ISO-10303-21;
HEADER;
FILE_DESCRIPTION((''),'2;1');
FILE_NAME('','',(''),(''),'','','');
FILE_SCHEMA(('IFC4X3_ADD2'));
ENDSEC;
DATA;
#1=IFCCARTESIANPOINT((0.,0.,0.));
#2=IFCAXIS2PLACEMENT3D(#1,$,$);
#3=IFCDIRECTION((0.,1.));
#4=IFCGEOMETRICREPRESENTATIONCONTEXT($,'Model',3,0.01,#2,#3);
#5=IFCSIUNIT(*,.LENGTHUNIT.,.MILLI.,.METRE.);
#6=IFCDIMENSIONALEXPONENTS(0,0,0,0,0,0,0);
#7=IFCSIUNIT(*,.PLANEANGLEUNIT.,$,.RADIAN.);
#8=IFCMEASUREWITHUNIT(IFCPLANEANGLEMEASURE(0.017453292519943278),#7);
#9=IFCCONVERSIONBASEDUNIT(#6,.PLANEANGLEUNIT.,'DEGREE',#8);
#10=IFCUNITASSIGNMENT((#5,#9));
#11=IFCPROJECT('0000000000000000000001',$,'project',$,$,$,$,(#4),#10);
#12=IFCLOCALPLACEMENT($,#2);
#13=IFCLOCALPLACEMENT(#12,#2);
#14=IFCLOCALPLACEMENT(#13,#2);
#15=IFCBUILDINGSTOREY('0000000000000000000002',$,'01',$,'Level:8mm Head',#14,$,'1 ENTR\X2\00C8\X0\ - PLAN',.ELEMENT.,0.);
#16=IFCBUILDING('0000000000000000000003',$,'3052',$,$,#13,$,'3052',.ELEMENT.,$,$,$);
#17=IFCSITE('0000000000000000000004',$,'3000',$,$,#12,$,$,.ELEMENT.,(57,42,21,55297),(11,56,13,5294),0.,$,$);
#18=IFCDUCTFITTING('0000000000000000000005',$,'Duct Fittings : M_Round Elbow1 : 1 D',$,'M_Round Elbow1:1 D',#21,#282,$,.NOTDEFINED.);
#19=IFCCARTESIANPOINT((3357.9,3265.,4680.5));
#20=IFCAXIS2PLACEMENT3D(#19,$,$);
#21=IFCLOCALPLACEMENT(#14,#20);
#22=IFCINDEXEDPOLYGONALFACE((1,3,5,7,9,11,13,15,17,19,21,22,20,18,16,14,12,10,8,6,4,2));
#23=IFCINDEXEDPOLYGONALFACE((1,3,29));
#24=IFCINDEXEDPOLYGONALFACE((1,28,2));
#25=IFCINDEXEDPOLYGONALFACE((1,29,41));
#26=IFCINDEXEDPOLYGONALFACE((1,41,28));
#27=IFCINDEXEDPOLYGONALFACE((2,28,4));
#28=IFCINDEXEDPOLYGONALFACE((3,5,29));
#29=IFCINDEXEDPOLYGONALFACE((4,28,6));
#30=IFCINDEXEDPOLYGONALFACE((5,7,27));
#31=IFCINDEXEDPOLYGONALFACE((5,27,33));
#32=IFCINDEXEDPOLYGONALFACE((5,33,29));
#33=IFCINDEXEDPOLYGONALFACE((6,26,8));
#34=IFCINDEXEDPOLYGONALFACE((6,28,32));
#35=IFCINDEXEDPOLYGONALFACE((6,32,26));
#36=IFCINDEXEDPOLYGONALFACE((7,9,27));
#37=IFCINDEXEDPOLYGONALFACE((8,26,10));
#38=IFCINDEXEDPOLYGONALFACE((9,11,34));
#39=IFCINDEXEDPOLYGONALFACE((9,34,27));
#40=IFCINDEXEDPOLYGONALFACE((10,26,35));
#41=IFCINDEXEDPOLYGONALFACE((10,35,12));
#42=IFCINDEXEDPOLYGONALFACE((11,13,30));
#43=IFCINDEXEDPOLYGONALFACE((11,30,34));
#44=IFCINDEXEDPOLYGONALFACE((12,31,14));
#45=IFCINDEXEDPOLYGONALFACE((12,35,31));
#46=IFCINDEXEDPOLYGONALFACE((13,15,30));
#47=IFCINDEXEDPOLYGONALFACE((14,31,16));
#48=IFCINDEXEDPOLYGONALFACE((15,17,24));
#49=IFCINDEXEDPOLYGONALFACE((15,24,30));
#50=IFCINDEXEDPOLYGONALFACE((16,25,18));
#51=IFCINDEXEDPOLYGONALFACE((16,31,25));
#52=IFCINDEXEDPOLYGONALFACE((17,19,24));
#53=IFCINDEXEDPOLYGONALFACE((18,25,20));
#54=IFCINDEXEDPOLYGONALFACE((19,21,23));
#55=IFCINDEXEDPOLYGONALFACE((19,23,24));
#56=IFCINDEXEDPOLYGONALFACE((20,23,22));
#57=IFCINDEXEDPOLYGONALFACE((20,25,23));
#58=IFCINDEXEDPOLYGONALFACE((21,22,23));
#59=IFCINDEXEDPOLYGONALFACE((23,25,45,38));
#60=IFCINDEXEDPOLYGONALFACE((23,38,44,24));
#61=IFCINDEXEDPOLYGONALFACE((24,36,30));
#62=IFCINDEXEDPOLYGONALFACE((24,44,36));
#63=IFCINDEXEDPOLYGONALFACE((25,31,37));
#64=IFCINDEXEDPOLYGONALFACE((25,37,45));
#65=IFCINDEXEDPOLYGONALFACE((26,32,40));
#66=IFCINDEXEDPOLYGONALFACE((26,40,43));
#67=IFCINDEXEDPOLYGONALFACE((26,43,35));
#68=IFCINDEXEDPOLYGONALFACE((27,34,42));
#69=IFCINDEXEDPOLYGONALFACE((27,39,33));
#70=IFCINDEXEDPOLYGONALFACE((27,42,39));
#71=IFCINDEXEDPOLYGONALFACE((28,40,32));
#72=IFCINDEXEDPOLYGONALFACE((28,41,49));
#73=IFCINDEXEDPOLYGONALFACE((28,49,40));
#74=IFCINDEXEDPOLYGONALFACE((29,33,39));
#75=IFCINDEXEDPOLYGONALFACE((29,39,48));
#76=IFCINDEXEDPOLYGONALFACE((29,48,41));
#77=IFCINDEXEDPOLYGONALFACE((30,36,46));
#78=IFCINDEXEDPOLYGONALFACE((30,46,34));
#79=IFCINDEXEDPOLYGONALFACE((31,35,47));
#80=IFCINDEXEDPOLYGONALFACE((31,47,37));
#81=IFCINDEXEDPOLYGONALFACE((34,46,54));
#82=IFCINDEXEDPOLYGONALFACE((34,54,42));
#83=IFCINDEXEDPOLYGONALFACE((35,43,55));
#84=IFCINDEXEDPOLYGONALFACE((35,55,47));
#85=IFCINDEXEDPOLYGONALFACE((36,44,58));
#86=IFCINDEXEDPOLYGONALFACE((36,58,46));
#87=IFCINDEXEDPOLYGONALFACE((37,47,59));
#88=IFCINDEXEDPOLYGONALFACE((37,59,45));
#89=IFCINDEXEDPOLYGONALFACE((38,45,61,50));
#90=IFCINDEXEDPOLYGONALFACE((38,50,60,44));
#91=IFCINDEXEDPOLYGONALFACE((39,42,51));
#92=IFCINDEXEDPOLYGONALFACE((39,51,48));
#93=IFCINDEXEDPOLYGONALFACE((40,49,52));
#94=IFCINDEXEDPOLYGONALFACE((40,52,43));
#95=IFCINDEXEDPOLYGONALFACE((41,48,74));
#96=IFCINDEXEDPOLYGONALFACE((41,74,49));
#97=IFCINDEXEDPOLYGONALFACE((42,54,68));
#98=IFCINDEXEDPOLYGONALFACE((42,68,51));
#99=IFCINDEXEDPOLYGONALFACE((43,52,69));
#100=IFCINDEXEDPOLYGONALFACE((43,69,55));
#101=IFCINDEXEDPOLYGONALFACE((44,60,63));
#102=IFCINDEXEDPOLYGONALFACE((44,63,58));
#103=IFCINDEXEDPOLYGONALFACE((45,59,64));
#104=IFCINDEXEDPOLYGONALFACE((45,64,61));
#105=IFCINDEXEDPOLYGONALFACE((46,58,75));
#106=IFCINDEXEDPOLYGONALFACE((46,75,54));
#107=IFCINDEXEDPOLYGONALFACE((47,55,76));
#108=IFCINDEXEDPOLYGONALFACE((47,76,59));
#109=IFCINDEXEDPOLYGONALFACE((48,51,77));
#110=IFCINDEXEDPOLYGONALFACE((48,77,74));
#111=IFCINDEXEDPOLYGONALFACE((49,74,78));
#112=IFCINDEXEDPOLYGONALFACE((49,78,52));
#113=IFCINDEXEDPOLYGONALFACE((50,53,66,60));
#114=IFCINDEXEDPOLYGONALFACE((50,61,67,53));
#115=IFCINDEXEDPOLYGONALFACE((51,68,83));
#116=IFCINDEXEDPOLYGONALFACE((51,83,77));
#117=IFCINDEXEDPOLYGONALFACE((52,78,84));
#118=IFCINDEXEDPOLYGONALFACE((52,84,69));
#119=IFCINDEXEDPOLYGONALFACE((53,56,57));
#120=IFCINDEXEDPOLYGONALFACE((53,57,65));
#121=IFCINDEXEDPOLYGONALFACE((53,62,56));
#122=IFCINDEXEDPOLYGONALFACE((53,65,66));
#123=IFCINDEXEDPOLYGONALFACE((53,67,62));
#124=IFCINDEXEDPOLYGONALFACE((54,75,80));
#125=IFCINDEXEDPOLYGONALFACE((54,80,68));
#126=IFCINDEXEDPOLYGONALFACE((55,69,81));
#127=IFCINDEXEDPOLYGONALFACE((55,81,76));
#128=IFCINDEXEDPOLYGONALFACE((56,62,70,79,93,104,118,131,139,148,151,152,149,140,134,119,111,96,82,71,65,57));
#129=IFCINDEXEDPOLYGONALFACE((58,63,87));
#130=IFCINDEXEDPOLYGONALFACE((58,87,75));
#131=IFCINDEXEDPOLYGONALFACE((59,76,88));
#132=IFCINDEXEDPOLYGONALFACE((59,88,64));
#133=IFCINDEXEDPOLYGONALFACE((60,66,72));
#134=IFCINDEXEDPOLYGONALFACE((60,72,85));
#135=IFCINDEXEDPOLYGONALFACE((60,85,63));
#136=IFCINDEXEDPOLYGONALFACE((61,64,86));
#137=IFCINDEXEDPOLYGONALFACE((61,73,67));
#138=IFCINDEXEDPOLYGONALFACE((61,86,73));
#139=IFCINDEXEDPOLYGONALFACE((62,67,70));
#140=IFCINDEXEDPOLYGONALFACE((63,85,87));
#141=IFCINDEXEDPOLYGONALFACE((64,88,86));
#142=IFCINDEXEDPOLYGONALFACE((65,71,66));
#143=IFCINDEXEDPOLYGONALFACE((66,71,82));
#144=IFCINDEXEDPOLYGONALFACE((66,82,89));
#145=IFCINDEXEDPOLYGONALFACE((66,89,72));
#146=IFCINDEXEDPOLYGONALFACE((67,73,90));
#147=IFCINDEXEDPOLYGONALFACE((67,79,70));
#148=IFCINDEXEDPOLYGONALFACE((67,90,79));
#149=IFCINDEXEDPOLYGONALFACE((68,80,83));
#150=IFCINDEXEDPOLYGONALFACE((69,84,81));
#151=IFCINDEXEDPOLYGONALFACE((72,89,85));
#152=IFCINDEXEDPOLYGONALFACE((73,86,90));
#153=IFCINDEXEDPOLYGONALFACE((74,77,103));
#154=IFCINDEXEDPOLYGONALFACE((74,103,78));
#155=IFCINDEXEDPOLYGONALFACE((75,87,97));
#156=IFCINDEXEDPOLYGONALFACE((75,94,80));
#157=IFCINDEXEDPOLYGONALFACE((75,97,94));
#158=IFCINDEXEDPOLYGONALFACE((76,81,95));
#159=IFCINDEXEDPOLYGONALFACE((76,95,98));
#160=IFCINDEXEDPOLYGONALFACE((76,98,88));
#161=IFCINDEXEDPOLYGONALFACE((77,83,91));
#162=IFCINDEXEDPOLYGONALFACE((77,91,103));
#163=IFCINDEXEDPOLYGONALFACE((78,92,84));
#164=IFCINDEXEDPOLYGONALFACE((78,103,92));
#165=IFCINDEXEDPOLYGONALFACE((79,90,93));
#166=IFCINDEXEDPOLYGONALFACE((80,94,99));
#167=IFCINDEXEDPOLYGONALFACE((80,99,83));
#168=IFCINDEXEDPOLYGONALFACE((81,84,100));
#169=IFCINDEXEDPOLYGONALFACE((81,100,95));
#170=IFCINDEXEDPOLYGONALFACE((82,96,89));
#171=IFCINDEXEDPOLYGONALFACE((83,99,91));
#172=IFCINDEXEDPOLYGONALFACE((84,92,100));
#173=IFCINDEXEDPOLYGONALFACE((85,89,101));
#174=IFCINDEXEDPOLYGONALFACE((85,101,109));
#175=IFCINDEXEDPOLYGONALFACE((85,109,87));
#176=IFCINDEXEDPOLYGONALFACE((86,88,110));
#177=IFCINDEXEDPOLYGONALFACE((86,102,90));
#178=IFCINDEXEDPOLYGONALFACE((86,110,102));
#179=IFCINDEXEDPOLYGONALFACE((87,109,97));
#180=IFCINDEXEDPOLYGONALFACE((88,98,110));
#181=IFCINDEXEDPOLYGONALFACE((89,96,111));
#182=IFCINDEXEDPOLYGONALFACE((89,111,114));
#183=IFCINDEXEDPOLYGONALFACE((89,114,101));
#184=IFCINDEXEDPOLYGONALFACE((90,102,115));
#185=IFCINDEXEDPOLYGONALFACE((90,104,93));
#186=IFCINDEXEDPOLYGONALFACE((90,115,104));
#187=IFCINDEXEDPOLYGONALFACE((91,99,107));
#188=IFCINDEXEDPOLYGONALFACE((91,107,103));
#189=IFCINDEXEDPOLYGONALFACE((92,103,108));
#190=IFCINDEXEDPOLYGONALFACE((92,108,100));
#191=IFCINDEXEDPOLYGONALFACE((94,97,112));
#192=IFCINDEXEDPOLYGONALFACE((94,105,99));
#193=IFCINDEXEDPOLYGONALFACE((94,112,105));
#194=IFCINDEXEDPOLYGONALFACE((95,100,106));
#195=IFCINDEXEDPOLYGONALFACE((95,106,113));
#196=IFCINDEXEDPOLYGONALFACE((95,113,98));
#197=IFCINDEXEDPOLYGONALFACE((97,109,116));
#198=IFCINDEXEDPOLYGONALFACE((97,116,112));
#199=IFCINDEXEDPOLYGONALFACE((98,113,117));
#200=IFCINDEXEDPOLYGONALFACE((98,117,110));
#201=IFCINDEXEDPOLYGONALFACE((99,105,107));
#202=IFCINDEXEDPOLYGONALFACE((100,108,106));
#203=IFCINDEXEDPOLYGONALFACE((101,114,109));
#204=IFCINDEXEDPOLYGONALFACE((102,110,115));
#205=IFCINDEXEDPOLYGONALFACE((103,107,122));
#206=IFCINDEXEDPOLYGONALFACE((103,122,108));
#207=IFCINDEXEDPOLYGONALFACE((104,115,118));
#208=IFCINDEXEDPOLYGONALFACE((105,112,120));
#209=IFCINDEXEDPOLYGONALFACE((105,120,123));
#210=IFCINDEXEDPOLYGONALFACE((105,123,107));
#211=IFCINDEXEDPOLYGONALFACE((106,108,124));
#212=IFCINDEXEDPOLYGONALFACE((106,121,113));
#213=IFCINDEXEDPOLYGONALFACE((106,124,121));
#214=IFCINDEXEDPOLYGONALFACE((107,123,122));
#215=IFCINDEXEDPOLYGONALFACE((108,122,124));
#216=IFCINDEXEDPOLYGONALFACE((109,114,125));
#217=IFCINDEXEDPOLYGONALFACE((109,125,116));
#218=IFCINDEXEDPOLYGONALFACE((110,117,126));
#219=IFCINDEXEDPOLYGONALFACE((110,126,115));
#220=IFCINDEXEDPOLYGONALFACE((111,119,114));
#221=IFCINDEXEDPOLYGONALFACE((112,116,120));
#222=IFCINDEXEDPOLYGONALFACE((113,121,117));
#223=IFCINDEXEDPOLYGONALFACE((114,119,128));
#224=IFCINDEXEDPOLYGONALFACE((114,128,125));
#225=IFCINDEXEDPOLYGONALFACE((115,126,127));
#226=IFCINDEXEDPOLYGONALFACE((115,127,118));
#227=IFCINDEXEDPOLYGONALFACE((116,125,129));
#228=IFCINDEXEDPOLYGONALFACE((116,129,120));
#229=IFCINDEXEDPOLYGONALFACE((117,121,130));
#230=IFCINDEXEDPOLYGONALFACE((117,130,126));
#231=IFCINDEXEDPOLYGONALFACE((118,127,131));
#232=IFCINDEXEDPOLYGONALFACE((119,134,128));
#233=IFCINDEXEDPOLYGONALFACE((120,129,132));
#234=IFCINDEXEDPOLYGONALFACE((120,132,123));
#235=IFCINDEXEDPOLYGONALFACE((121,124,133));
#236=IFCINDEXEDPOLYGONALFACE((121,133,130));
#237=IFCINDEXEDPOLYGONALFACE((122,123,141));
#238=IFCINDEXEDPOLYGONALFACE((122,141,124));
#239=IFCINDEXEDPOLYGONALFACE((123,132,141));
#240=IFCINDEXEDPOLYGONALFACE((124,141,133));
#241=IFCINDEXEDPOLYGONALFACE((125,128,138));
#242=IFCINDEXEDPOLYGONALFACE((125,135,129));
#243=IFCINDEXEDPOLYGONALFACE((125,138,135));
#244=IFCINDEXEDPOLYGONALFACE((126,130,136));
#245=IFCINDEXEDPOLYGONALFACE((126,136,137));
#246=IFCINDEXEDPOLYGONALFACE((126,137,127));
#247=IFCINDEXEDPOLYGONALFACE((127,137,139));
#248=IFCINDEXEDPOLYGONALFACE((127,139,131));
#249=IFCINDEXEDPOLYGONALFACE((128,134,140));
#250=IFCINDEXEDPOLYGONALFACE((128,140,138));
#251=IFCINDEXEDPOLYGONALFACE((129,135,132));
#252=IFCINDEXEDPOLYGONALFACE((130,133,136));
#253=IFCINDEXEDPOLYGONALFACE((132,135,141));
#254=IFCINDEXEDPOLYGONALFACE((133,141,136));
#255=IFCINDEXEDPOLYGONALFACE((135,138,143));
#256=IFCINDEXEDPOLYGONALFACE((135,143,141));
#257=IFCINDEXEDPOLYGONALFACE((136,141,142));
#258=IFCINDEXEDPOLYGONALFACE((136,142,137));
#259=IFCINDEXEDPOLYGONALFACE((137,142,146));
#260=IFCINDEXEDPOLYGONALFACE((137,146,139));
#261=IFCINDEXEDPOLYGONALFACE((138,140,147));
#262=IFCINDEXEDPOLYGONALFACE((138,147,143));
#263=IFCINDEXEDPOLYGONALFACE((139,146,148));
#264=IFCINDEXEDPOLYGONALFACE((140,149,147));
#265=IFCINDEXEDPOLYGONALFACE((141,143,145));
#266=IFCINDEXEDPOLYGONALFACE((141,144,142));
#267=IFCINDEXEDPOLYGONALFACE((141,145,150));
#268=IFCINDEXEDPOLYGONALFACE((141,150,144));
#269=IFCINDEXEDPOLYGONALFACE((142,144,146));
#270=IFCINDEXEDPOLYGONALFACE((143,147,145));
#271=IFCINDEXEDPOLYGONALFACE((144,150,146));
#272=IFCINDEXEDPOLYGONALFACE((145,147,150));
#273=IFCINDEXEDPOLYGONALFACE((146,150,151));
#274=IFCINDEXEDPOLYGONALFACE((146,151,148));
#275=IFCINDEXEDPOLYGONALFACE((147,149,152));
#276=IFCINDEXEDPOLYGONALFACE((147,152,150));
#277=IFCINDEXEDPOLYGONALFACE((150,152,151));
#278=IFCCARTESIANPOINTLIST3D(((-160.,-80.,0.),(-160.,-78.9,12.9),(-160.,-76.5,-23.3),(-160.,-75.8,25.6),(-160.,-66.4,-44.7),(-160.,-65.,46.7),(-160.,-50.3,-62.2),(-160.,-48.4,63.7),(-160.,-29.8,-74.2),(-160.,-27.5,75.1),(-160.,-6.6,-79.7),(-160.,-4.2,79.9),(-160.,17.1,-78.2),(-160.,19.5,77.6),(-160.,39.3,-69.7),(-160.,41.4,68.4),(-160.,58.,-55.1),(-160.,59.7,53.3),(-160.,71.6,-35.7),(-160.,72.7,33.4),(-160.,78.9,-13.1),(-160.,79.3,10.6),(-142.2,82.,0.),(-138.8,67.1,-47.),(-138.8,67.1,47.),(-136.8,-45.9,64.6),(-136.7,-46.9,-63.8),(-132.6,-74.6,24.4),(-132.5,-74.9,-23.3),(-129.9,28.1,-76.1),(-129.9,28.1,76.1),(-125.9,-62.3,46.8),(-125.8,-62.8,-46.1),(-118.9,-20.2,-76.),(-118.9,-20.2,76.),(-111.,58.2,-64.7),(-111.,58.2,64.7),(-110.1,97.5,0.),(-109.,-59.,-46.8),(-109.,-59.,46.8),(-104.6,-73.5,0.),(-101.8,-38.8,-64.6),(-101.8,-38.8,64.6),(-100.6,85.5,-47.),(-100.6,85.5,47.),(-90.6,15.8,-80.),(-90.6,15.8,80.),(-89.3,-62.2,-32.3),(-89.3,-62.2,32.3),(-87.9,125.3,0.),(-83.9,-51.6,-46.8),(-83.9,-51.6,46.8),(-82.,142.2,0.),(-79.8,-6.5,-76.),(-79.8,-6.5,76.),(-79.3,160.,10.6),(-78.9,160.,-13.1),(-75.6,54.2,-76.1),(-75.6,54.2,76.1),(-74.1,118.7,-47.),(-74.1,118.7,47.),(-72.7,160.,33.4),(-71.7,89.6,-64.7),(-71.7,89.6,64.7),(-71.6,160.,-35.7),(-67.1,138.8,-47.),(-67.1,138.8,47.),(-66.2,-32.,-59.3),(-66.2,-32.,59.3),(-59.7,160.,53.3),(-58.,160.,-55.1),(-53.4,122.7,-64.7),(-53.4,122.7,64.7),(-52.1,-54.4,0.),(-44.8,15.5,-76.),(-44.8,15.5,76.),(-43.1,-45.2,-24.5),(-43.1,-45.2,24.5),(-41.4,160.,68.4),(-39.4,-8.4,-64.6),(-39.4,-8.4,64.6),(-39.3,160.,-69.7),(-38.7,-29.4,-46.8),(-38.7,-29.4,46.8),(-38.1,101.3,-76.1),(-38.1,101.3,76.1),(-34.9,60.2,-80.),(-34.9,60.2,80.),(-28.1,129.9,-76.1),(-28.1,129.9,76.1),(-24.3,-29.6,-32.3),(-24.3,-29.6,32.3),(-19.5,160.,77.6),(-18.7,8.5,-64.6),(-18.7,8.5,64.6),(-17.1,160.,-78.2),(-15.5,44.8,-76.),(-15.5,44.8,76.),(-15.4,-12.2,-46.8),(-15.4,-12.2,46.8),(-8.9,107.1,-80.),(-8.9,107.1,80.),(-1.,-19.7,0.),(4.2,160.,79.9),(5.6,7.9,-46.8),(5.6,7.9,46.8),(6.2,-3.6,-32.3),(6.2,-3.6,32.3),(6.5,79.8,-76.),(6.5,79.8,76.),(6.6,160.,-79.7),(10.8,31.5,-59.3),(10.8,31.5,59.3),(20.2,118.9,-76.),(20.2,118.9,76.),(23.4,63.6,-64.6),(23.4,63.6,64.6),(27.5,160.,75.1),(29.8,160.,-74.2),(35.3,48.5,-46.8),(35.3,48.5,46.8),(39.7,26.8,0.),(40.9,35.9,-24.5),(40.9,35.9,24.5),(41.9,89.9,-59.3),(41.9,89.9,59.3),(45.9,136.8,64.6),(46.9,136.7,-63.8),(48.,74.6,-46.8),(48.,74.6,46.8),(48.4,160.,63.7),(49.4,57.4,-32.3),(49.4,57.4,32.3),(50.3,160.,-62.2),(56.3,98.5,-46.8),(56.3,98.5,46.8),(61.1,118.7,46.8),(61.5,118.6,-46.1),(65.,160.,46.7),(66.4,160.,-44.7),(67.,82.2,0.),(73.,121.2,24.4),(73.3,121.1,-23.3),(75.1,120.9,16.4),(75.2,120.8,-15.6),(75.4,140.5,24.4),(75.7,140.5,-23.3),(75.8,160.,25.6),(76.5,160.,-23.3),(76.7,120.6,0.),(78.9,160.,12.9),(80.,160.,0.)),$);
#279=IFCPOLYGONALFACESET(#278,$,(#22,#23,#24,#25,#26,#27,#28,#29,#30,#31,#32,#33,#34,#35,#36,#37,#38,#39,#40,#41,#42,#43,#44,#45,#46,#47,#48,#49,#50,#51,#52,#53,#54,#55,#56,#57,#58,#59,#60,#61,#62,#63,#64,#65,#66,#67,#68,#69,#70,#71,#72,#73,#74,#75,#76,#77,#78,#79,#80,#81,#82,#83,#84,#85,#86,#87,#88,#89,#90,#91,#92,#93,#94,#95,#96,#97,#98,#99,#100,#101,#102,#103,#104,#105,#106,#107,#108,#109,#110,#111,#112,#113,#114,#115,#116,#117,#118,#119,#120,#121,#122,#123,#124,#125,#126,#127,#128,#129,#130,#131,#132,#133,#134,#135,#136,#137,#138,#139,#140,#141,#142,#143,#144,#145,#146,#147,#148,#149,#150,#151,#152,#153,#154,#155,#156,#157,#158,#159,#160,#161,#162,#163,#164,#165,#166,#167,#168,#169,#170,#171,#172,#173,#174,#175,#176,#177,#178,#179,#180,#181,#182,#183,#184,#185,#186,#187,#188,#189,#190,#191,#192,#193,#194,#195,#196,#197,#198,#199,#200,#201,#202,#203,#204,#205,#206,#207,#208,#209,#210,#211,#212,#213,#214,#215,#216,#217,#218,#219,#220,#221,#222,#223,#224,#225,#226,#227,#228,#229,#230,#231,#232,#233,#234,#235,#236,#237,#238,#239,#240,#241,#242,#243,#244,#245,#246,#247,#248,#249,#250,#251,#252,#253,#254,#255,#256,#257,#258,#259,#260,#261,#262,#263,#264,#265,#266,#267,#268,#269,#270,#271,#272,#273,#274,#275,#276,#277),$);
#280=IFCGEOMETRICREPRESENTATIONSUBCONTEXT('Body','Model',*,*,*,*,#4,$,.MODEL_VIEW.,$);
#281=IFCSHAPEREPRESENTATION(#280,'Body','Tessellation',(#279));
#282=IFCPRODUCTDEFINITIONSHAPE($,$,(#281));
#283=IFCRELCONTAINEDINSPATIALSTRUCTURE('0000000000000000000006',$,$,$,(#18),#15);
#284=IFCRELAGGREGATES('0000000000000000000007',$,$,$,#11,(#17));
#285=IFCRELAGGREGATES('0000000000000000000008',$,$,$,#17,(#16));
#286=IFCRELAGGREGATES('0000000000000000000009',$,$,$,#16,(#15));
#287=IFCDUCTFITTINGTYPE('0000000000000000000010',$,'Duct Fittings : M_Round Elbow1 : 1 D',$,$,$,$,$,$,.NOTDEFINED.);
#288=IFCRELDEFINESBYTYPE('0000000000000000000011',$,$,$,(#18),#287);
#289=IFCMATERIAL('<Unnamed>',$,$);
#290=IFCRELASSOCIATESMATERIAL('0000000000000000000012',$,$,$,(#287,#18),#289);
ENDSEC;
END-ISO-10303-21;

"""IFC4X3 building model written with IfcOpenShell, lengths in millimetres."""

from ifc_helpers import new_model, entity, si_unit, converted_unit, direction, frame, origin, place, context, subcontext, project, spatial, source, transform, mapped, material, type_object, type_shapes, element, save


model = new_model("IFC4X3")

# Units and contexts
model_context = context("Model", 3, precision=0.01, world=origin(), true_north=direction((0.0, 1.0)))
body_context = subcontext(model_context, "Body", "Model", "MODEL_VIEW")
ifc_project = project(units=[si_unit("LENGTHUNIT", "METRE", prefix="MILLI"), converted_unit("PLANEANGLEUNIT", "DEGREE", entity("IfcPlaneAngleMeasure", 0.017453292519943278), si_unit("PLANEANGLEUNIT", "RADIAN"), dimensions=[0, 0, 0, 0, 0, 0, 0])], contexts=[model_context])

# Site, building, storey
site_placement = place(None, origin())
site = spatial("IfcSite", under=ifc_project, at=site_placement, Name="3000", CompositionType="ELEMENT", RefLatitude=(57, 42, 21, 55297), RefLongitude=(11, 56, 13, 5294), RefElevation=0.0)
building_placement = place(site_placement, origin())
building = spatial("IfcBuilding", under=site, at=building_placement, Name="3052", LongName="3052", CompositionType="ELEMENT")
storey_placement = place(building_placement, origin())
storey = spatial("IfcBuildingStorey", under=building, at=storey_placement, Name="01", ObjectType="Level:8mm Head", LongName="1 ENTRÈ - PLAN", CompositionType="ELEMENT", Elevation=0.0)

# Shared definitions
ifc_material_1 = material(Name="<Unnamed>")

# Duct fitting
duct_fitting_type_1 = type_object("IfcDuctFittingType", Name="Duct Fittings : M_Round Elbow1 : 1 D", PredefinedType="NOTDEFINED", material=ifc_material_1)
ifc_direction_1 = entity("IfcDirection", [0.0, 0.0, 1.0])
trimmed_curve_1 = entity("IfcTrimmedCurve", entity("IfcCircle", entity("IfcAxis2Placement2D", entity("IfcCartesianPoint", [-160.0, 0.0]), entity("IfcDirection", [0.0, 1.0])), 160.0), [entity("IfcParameterValue", 270.0)], [entity("IfcParameterValue", 0.000003)], True, "PARAMETER")
shared_shape_1 = source(origin(), body_context, "Body", "AdvancedSweptSolid", [
    entity("IfcSurfaceCurveSweptAreaSolid", entity("IfcCircleProfileDef", "AREA", None, entity("IfcAxis2Placement2D", entity("IfcCartesianPoint", [0.0, 0.0]), entity("IfcDirection", [1.0, 0.0])), 80.0), entity("IfcAxis2Placement3D", entity("IfcCartesianPoint", [-160.0, 0.0, 0.0]), ifc_direction_1, entity("IfcDirection", [0.0, -1.0, 0.0])), trimmed_curve_1, entity("IfcParameterValue", 0.0), entity("IfcParameterValue", 90.000003), entity("IfcSurfaceOfLinearExtrusion", entity("IfcArbitraryOpenProfileDef", "CURVE", None, trimmed_curve_1), entity("IfcAxis2Placement3D", entity("IfcCartesianPoint", [0.0, 0.0, -304.8])), ifc_direction_1, 1.0)),
])
type_shapes(duct_fitting_type_1, [shared_shape_1])
duct_fitting_1_placement = place(storey_placement, frame((3357.9, 3265.0, 4680.5)))
element("IfcDuctFitting", 1, at=duct_fitting_1_placement, inside=storey, type_object=duct_fitting_type_1, material=ifc_material_1, Name="Duct Fittings : M_Round Elbow1 : 1 D", ObjectType="M_Round Elbow1:1 D", PredefinedType="NOTDEFINED", context=body_context, shape_type="MappedRepresentation", body=[
    mapped(shared_shape_1, transform((0.0, 0.0, 0.0), scale=1.0)),
])

save(model, "model.ifc")
